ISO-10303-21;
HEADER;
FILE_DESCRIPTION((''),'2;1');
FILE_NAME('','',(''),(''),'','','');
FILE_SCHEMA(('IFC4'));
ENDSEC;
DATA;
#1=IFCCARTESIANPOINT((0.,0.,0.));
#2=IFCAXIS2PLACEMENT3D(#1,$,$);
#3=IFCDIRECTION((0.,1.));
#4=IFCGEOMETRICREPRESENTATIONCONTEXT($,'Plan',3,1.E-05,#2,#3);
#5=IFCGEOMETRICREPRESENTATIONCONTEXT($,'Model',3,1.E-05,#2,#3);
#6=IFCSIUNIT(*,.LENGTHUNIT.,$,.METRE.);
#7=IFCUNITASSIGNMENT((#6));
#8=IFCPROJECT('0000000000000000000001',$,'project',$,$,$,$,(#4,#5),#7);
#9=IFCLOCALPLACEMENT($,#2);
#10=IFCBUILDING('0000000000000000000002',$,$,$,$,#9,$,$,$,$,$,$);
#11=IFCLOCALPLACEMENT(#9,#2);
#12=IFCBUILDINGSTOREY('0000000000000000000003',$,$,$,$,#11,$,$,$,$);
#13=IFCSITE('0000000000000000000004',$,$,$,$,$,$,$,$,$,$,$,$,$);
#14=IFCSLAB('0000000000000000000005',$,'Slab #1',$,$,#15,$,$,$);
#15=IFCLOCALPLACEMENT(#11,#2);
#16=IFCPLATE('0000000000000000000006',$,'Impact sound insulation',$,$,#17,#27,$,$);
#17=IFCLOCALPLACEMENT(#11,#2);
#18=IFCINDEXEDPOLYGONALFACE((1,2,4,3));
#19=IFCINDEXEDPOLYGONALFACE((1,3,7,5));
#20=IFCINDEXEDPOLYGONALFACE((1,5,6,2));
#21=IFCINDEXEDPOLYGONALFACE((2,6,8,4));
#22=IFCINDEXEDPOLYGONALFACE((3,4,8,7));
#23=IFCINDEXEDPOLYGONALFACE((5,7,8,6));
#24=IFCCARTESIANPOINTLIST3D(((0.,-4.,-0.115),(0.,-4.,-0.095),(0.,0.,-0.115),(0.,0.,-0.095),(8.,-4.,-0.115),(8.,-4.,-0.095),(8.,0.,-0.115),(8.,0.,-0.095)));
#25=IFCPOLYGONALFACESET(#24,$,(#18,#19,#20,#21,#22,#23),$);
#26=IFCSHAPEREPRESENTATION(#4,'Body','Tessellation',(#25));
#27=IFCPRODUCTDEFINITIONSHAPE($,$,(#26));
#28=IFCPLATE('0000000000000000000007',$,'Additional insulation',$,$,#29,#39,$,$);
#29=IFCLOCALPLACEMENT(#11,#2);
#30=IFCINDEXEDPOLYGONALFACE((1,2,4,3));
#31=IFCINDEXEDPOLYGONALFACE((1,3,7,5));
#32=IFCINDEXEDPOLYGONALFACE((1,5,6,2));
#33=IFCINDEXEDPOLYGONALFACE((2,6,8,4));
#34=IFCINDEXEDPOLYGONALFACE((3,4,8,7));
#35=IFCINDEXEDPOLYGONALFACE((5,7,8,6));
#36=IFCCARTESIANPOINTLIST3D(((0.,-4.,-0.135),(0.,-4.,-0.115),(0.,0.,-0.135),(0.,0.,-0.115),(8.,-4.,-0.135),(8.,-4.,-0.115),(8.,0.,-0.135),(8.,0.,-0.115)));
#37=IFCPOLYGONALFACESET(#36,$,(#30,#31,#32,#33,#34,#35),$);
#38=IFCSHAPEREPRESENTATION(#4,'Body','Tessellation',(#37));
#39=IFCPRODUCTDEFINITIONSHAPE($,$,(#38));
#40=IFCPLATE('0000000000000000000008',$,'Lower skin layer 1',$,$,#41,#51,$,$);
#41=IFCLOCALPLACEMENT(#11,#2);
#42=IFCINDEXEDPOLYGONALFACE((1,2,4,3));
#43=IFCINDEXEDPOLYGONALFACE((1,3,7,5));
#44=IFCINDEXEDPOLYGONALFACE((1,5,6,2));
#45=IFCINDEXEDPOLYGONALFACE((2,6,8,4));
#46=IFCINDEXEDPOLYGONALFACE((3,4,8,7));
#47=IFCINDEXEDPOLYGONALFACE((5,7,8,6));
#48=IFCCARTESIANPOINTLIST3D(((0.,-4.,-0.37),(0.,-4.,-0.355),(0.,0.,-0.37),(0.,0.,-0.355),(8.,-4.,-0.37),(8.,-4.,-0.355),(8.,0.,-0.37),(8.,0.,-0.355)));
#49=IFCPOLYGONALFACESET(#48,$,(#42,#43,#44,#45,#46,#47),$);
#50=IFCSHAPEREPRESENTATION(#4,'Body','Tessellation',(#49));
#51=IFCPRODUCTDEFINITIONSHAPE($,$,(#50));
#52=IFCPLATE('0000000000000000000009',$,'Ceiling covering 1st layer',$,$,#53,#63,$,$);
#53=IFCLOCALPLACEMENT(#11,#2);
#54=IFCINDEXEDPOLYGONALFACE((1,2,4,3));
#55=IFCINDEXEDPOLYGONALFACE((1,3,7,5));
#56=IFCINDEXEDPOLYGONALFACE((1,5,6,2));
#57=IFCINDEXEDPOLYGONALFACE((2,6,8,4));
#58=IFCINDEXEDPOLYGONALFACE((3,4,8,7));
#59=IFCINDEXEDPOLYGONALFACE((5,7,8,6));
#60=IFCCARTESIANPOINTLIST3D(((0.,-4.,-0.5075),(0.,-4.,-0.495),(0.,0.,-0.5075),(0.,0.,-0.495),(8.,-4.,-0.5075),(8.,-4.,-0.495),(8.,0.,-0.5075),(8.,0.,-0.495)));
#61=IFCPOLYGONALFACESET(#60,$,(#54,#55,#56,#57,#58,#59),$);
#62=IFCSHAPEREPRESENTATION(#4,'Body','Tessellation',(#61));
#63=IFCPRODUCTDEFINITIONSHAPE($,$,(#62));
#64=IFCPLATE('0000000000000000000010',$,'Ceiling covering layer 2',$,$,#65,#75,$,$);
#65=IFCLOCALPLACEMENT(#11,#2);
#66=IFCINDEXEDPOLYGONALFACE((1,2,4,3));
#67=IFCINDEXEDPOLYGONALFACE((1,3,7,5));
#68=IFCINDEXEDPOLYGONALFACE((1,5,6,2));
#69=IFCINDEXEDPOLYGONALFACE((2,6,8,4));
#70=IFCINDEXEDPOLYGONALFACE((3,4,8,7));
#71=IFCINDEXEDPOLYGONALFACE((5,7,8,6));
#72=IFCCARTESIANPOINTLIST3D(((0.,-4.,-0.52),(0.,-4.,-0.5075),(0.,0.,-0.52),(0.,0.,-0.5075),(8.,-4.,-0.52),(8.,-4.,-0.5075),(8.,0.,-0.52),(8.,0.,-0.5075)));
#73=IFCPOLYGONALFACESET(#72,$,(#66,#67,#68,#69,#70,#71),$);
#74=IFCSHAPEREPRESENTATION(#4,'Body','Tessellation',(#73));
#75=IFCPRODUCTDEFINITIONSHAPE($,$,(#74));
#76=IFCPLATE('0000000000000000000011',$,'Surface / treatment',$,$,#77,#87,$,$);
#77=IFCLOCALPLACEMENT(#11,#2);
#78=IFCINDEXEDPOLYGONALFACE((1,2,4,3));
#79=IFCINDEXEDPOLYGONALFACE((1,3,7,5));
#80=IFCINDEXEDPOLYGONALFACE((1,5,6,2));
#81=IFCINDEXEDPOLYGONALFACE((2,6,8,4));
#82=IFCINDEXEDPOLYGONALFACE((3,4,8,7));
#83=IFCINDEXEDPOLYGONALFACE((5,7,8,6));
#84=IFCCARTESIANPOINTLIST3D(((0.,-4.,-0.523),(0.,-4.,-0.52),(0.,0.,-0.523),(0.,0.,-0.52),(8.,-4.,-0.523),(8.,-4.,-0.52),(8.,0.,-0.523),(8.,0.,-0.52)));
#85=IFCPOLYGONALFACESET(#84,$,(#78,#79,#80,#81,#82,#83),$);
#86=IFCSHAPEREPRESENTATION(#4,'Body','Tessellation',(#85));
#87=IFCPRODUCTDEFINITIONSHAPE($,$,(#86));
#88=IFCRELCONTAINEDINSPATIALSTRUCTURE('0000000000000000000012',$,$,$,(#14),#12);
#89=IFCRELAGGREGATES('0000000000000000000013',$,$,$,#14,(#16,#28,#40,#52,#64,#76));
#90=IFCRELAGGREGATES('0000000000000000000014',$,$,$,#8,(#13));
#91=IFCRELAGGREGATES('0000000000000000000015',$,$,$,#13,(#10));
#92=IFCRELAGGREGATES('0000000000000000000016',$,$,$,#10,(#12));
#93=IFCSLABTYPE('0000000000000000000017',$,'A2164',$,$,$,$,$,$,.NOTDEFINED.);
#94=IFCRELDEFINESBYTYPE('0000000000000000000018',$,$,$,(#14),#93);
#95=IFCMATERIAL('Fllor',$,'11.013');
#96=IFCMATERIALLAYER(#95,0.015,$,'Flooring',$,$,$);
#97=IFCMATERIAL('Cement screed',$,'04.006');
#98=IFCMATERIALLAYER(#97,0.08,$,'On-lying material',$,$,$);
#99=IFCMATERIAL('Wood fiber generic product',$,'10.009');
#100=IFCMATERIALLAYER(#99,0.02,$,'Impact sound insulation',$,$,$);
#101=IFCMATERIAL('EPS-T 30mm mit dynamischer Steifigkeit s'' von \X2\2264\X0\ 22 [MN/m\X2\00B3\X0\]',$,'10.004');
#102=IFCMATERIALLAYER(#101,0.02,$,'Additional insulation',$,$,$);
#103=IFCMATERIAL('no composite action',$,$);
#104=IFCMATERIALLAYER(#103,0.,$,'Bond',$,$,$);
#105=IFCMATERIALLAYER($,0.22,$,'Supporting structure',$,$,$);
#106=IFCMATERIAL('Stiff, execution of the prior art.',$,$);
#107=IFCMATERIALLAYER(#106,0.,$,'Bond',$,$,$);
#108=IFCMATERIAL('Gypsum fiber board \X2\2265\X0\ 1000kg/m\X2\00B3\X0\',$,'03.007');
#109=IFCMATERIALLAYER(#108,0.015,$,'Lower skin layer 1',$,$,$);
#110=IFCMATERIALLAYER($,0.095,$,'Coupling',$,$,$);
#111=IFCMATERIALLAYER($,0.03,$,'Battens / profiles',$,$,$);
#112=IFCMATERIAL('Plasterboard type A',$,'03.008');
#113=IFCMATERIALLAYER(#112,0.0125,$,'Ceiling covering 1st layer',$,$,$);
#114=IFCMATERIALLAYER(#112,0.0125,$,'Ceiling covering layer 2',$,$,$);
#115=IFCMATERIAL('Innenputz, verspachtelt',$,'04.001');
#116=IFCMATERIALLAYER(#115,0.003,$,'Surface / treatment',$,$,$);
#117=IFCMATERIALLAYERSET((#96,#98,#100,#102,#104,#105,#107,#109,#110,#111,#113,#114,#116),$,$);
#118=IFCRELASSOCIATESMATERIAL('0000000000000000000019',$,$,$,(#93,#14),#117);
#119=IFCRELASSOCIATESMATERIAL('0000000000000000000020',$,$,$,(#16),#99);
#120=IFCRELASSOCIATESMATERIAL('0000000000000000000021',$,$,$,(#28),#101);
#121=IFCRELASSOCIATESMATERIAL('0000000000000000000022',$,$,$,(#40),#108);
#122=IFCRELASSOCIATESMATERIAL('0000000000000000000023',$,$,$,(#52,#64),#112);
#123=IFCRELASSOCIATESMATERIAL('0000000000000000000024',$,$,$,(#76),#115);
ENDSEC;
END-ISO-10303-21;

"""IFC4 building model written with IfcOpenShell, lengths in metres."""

from ifc_helpers import new_model, si_unit, direction, frame, frame_2d, origin, place, context, project, spatial, rectangle, extrude, material, layer, layer_set, type_object, element, aggregate, save


model = new_model("IFC4")

# Units and contexts
plan_context = context("Plan", 3, precision=1e-05, world=origin(), true_north=direction((0.0, 1.0)))
model_context = context("Model", 3, precision=1e-05, world=origin(), true_north=direction((0.0, 1.0)))
ifc_project = project(units=[si_unit("LENGTHUNIT", "METRE")], contexts=[plan_context, model_context])

# Site, building, storey
site = spatial("IfcSite", under=ifc_project)
building_placement = place(None, origin())
building = spatial("IfcBuilding", under=site, at=building_placement)
storey_placement = place(building_placement, origin())
storey = spatial("IfcBuildingStorey", under=building, at=storey_placement)

# Slab, plates
ifc_material_1 = material(Name="Fllor", Category="11.013")
ifc_layer_1 = layer(ifc_material_1, 0.015, Name="Flooring")
ifc_material_2 = material(Name="Cement screed", Category="04.006")
ifc_layer_2 = layer(ifc_material_2, 0.08, Name="On-lying material")
ifc_material_3 = material(Name="Wood fiber generic product", Category="10.009")
ifc_layer_3 = layer(ifc_material_3, 0.02, Name="Impact sound insulation")
ifc_material_4 = material(Name="EPS-T 30mm mit dynamischer Steifigkeit s' von ≤ 22 [MN/m³]", Category="10.004")
ifc_layer_4 = layer(ifc_material_4, 0.02, Name="Additional insulation")
ifc_material_5 = material(Name="no composite action")
ifc_layer_5 = layer(ifc_material_5, 0.0, Name="Bond")
ifc_layer_6 = layer(None, 0.22, Name="Supporting structure")
ifc_material_6 = material(Name="Stiff, execution of the prior art.")
ifc_layer_7 = layer(ifc_material_6, 0.0, Name="Bond")
ifc_material_7 = material(Name="Gypsum fiber board ≥ 1000kg/m³", Category="03.007")
ifc_layer_8 = layer(ifc_material_7, 0.015, Name="Lower skin layer 1")
ifc_layer_9 = layer(None, 0.095, Name="Coupling")
ifc_layer_10 = layer(None, 0.03, Name="Battens / profiles")
ifc_material_8 = material(Name="Plasterboard type A", Category="03.008")
ifc_layer_11 = layer(ifc_material_8, 0.0125, Name="Ceiling covering 1st layer")
ifc_layer_12 = layer(ifc_material_8, 0.0125, Name="Ceiling covering layer 2")
ifc_material_9 = material(Name="Innenputz, verspachtelt", Category="04.001")
ifc_layer_13 = layer(ifc_material_9, 0.003, Name="Surface / treatment")
ifc_layer_set = layer_set([ifc_layer_1, ifc_layer_2, ifc_layer_3, ifc_layer_4, ifc_layer_5, ifc_layer_6, ifc_layer_7, ifc_layer_8, ifc_layer_9, ifc_layer_10, ifc_layer_11, ifc_layer_12, ifc_layer_13])
slab_type = type_object("IfcSlabType", Name="A2164", PredefinedType="NOTDEFINED", material=ifc_layer_set)
slab_placement = place(None, frame((0.0, 0.0, 0.0), z_axis=(0.0, 0.0, -1.0), x_axis=(1.0, 0.0, 0.0)))
slab = element("IfcSlab", 1, at=slab_placement, inside=storey, type_object=slab_type, material=ifc_layer_set, Name="Slab #1")
plate_1_placement = place(slab_placement, origin())
plate_1 = element("IfcPlate", 2, at=plate_1_placement, material=ifc_material_3, Name="Impact sound insulation", context=plan_context, shape_type="SweptSolid", body=[
    extrude(rectangle(XDim=8.0, YDim=4.0, at=frame_2d((4.0, 2.0), x_axis=(1.0, 0.0))), frame((0.0, 0.0, 0.095), z_axis=(0.0, 0.0, 1.0), x_axis=(1.0, 0.0, 0.0)), (0.0, 0.0, 1.0), 0.02),
])
plate_2_placement = place(slab_placement, origin())
plate_2 = element("IfcPlate", 3, at=plate_2_placement, material=ifc_material_4, Name="Additional insulation", context=plan_context, shape_type="SweptSolid", body=[
    extrude(rectangle(XDim=8.0, YDim=4.0, at=frame_2d((4.0, 2.0), x_axis=(1.0, 0.0))), frame((0.0, 0.0, 0.115), z_axis=(0.0, 0.0, 1.0), x_axis=(1.0, 0.0, 0.0)), (0.0, 0.0, 1.0), 0.02),
])
plate_3_placement = place(slab_placement, origin())
plate_3 = element("IfcPlate", 4, at=plate_3_placement, material=ifc_material_7, Name="Lower skin layer 1", context=plan_context, shape_type="SweptSolid", body=[
    extrude(rectangle(XDim=8.0, YDim=4.0, at=frame_2d((4.0, 2.0), x_axis=(1.0, 0.0))), frame((0.0, 0.0, 0.355), z_axis=(0.0, 0.0, 1.0), x_axis=(1.0, 0.0, 0.0)), (0.0, 0.0, 1.0), 0.015),
])
plate_4_placement = place(slab_placement, origin())
plate_4 = element("IfcPlate", 5, at=plate_4_placement, material=ifc_material_8, Name="Ceiling covering 1st layer", context=plan_context, shape_type="SweptSolid", body=[
    extrude(rectangle(XDim=8.0, YDim=4.0, at=frame_2d((4.0, 2.0), x_axis=(1.0, 0.0))), frame((0.0, 0.0, 0.495), z_axis=(0.0, 0.0, 1.0), x_axis=(1.0, 0.0, 0.0)), (0.0, 0.0, 1.0), 0.0125),
])
plate_5_placement = place(slab_placement, origin())
plate_5 = element("IfcPlate", 6, at=plate_5_placement, material=ifc_material_8, Name="Ceiling covering layer 2", context=plan_context, shape_type="SweptSolid", body=[
    extrude(rectangle(XDim=8.0, YDim=4.0, at=frame_2d((4.0, 2.0), x_axis=(1.0, 0.0))), frame((0.0, 0.0, 0.5075), z_axis=(0.0, 0.0, 1.0), x_axis=(1.0, 0.0, 0.0)), (0.0, 0.0, 1.0), 0.0125),
])
plate_6_placement = place(slab_placement, origin())
plate_6 = element("IfcPlate", 7, at=plate_6_placement, material=ifc_material_9, Name="Surface / treatment", context=plan_context, shape_type="SweptSolid", body=[
    extrude(rectangle(XDim=8.0, YDim=4.0, at=frame_2d((4.0, 2.0), x_axis=(1.0, 0.0))), frame((0.0, 0.0, 0.52), z_axis=(0.0, 0.0, 1.0), x_axis=(1.0, 0.0, 0.0)), (0.0, 0.0, 1.0), 0.003),
])
aggregate(slab, [plate_1, plate_2, plate_3, plate_4, plate_5, plate_6])

save(model, "model.ifc")
